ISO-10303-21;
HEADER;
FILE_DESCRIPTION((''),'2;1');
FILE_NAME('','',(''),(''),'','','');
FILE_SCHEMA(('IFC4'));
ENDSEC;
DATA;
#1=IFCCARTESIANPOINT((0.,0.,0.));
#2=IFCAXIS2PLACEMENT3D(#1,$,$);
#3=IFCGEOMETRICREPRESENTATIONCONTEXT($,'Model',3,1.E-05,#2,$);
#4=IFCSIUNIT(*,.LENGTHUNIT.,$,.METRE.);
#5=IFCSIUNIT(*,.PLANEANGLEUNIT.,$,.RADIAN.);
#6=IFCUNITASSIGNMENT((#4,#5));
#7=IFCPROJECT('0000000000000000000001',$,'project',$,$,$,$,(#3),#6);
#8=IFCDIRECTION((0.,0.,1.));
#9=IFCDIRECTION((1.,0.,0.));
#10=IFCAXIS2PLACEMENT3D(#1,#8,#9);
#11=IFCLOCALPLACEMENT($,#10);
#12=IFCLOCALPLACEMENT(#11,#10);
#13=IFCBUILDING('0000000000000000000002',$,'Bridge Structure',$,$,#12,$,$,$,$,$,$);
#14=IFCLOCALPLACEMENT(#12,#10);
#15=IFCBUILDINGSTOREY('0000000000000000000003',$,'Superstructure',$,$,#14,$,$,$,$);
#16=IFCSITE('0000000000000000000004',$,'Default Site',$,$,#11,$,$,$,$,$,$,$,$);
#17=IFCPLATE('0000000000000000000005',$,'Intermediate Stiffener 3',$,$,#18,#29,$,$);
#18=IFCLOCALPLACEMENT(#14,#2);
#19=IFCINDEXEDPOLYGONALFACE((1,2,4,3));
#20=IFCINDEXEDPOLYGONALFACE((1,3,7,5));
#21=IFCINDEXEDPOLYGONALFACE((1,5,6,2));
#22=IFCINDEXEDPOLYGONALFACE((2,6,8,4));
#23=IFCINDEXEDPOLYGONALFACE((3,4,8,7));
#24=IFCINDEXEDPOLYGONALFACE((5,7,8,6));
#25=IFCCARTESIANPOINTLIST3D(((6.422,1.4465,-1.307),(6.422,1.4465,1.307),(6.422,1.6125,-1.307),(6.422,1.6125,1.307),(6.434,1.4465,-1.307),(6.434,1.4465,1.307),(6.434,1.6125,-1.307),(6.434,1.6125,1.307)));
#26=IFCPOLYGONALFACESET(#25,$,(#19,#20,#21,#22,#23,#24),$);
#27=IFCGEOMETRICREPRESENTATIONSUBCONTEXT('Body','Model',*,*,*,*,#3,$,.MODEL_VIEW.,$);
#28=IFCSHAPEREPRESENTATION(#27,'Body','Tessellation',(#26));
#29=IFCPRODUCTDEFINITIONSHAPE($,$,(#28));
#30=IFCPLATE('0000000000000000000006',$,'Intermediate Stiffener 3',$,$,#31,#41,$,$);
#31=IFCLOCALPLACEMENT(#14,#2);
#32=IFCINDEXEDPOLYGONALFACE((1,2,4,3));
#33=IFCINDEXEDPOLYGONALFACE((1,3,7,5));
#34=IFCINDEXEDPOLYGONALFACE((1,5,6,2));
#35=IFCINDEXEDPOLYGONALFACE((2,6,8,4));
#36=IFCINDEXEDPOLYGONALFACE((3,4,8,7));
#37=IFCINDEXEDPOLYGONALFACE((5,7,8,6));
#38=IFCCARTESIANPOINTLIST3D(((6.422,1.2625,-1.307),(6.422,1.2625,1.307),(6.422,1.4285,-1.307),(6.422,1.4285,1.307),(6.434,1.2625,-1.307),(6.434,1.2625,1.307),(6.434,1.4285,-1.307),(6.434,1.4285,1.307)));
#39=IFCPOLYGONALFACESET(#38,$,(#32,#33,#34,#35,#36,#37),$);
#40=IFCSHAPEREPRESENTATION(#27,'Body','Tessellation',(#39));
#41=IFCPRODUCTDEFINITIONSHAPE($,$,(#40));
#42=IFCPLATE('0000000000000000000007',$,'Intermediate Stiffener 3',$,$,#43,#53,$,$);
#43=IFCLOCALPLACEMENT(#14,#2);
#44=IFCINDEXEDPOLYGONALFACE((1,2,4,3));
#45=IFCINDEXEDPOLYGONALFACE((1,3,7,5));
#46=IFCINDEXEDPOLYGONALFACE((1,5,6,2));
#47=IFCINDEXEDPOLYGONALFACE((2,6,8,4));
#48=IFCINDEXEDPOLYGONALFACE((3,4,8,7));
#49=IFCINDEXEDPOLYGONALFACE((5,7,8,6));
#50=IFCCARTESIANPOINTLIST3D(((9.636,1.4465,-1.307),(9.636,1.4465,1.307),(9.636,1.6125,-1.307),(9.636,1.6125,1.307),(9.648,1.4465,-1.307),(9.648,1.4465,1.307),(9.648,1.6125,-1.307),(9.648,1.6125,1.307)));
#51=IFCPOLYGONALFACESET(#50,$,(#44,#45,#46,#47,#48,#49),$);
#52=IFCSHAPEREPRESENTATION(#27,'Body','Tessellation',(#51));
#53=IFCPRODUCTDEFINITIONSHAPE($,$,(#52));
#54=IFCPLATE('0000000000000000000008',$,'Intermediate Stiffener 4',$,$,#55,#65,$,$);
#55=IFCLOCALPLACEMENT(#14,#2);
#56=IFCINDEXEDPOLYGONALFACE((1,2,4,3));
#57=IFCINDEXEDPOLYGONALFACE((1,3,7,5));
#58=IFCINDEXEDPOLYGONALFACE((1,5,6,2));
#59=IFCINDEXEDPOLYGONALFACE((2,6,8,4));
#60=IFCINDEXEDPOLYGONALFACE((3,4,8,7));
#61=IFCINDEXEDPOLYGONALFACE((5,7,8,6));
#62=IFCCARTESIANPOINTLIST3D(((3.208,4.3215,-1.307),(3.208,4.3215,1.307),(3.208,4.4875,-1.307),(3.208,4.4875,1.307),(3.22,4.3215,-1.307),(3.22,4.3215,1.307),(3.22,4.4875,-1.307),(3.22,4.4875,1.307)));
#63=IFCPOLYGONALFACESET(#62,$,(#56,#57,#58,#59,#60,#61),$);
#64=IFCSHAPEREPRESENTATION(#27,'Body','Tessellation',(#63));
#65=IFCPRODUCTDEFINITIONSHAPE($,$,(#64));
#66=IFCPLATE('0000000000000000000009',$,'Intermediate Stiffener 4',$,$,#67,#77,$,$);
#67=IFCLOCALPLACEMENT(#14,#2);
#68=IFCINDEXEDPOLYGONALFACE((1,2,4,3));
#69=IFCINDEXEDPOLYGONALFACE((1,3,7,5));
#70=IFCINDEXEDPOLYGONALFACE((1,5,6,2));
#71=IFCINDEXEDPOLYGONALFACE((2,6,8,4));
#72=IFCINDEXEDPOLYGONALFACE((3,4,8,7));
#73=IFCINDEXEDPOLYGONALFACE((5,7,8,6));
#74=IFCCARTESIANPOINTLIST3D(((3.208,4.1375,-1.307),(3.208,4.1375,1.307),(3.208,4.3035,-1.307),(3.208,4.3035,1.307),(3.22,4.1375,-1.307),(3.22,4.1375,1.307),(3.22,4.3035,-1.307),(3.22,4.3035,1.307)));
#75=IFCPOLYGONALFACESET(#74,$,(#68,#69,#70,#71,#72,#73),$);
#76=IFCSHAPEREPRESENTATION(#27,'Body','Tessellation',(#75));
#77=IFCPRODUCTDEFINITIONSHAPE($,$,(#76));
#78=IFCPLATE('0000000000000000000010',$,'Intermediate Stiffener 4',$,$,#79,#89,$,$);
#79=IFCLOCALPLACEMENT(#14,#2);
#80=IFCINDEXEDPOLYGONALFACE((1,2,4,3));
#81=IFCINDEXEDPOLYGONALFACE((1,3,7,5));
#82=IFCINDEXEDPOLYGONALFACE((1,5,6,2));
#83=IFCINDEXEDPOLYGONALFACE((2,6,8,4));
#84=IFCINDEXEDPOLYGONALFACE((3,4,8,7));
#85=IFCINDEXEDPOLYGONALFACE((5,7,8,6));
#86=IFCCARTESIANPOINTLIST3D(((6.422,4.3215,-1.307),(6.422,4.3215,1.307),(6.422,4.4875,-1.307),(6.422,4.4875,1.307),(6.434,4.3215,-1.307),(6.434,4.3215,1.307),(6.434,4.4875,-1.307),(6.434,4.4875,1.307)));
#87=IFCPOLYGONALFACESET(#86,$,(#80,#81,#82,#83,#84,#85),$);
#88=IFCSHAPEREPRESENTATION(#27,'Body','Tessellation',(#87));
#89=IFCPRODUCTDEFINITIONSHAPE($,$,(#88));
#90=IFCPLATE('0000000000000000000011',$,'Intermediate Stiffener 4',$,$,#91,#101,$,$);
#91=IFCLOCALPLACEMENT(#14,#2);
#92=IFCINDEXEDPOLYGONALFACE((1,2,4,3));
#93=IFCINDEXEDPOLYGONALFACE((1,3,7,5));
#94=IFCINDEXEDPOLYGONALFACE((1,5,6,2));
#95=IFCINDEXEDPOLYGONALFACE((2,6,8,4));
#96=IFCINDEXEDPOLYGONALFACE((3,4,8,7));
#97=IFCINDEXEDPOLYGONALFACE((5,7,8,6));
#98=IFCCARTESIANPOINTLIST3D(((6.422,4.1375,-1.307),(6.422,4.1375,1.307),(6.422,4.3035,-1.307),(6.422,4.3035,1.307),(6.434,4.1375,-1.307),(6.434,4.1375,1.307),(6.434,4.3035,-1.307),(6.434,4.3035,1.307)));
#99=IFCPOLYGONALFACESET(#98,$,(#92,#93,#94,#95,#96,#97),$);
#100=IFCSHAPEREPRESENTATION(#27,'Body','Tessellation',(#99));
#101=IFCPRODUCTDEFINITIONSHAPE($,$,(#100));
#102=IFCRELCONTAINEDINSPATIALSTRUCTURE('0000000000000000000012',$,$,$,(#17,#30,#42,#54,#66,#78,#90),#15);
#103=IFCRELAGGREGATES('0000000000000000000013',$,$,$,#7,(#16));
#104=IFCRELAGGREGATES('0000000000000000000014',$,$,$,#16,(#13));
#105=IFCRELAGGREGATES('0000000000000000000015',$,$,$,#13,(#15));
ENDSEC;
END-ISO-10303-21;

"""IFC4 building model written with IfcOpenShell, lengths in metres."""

from ifc_helpers import new_model, si_unit, frame, origin, origin_with_axes, origin_2d_with_axis, place, context, subcontext, project, spatial, rectangle, extrude, element, save


model = new_model("IFC4")

# Units and contexts
model_context = context("Model", 3, precision=1e-05, world=origin())
body_context = subcontext(model_context, "Body", "Model", "MODEL_VIEW")
ifc_project = project(units=[si_unit("LENGTHUNIT", "METRE"), si_unit("PLANEANGLEUNIT", "RADIAN")], contexts=[model_context])

# Site, building, storey
site_placement = place(None, origin_with_axes())
site = spatial("IfcSite", under=ifc_project, at=site_placement, Name="Default Site")
building_placement = place(site_placement, origin_with_axes())
building = spatial("IfcBuilding", under=site, at=building_placement, Name="Bridge Structure")
storey_placement = place(building_placement, origin_with_axes())
storey = spatial("IfcBuildingStorey", under=building, at=storey_placement, Name="Superstructure")

# Plates
for number, where, z_axis, x_axis, name in (
    (1, (6.428, 1.5295, -1.307), (0.0, 0.0, 1.0), (1.0, 0.0, 0.0), "Intermediate Stiffener 3"),
    (2, (6.428, 1.3455, -1.307), (0.0, 0.0, 1.0), (1.0, 0.0, 0.0), "Intermediate Stiffener 3"),
    (3, (9.642, 1.5295, -1.307), (0.0, 0.0, 1.0), (1.0, 0.0, 0.0), "Intermediate Stiffener 3"),
    (4, (3.214, 4.4045, -1.307), (0.0, 0.0, 1.0), (1.0, 0.0, 0.0), "Intermediate Stiffener 4"),
    (5, (3.214, 4.2205, -1.307), (0.0, 0.0, 1.0), (1.0, 0.0, 0.0), "Intermediate Stiffener 4"),
    (6, (6.428, 4.4045, -1.307), (0.0, 0.0, 1.0), (1.0, 0.0, 0.0), "Intermediate Stiffener 4"),
    (7, (6.428, 4.2205, -1.307), (0.0, 0.0, 1.0), (1.0, 0.0, 0.0), "Intermediate Stiffener 4"),
):
    element("IfcPlate", number, at=place(storey_placement, frame(where, z_axis=z_axis, x_axis=x_axis)), inside=storey, Name=name, context=body_context, shape_type="SweptSolid", body=[
        extrude(rectangle(XDim=0.012, YDim=0.166, at=origin_2d_with_axis()), origin_with_axes(), (0.0, 0.0, 1.0), 2.614),
    ])

save(model, "model.ifc")
